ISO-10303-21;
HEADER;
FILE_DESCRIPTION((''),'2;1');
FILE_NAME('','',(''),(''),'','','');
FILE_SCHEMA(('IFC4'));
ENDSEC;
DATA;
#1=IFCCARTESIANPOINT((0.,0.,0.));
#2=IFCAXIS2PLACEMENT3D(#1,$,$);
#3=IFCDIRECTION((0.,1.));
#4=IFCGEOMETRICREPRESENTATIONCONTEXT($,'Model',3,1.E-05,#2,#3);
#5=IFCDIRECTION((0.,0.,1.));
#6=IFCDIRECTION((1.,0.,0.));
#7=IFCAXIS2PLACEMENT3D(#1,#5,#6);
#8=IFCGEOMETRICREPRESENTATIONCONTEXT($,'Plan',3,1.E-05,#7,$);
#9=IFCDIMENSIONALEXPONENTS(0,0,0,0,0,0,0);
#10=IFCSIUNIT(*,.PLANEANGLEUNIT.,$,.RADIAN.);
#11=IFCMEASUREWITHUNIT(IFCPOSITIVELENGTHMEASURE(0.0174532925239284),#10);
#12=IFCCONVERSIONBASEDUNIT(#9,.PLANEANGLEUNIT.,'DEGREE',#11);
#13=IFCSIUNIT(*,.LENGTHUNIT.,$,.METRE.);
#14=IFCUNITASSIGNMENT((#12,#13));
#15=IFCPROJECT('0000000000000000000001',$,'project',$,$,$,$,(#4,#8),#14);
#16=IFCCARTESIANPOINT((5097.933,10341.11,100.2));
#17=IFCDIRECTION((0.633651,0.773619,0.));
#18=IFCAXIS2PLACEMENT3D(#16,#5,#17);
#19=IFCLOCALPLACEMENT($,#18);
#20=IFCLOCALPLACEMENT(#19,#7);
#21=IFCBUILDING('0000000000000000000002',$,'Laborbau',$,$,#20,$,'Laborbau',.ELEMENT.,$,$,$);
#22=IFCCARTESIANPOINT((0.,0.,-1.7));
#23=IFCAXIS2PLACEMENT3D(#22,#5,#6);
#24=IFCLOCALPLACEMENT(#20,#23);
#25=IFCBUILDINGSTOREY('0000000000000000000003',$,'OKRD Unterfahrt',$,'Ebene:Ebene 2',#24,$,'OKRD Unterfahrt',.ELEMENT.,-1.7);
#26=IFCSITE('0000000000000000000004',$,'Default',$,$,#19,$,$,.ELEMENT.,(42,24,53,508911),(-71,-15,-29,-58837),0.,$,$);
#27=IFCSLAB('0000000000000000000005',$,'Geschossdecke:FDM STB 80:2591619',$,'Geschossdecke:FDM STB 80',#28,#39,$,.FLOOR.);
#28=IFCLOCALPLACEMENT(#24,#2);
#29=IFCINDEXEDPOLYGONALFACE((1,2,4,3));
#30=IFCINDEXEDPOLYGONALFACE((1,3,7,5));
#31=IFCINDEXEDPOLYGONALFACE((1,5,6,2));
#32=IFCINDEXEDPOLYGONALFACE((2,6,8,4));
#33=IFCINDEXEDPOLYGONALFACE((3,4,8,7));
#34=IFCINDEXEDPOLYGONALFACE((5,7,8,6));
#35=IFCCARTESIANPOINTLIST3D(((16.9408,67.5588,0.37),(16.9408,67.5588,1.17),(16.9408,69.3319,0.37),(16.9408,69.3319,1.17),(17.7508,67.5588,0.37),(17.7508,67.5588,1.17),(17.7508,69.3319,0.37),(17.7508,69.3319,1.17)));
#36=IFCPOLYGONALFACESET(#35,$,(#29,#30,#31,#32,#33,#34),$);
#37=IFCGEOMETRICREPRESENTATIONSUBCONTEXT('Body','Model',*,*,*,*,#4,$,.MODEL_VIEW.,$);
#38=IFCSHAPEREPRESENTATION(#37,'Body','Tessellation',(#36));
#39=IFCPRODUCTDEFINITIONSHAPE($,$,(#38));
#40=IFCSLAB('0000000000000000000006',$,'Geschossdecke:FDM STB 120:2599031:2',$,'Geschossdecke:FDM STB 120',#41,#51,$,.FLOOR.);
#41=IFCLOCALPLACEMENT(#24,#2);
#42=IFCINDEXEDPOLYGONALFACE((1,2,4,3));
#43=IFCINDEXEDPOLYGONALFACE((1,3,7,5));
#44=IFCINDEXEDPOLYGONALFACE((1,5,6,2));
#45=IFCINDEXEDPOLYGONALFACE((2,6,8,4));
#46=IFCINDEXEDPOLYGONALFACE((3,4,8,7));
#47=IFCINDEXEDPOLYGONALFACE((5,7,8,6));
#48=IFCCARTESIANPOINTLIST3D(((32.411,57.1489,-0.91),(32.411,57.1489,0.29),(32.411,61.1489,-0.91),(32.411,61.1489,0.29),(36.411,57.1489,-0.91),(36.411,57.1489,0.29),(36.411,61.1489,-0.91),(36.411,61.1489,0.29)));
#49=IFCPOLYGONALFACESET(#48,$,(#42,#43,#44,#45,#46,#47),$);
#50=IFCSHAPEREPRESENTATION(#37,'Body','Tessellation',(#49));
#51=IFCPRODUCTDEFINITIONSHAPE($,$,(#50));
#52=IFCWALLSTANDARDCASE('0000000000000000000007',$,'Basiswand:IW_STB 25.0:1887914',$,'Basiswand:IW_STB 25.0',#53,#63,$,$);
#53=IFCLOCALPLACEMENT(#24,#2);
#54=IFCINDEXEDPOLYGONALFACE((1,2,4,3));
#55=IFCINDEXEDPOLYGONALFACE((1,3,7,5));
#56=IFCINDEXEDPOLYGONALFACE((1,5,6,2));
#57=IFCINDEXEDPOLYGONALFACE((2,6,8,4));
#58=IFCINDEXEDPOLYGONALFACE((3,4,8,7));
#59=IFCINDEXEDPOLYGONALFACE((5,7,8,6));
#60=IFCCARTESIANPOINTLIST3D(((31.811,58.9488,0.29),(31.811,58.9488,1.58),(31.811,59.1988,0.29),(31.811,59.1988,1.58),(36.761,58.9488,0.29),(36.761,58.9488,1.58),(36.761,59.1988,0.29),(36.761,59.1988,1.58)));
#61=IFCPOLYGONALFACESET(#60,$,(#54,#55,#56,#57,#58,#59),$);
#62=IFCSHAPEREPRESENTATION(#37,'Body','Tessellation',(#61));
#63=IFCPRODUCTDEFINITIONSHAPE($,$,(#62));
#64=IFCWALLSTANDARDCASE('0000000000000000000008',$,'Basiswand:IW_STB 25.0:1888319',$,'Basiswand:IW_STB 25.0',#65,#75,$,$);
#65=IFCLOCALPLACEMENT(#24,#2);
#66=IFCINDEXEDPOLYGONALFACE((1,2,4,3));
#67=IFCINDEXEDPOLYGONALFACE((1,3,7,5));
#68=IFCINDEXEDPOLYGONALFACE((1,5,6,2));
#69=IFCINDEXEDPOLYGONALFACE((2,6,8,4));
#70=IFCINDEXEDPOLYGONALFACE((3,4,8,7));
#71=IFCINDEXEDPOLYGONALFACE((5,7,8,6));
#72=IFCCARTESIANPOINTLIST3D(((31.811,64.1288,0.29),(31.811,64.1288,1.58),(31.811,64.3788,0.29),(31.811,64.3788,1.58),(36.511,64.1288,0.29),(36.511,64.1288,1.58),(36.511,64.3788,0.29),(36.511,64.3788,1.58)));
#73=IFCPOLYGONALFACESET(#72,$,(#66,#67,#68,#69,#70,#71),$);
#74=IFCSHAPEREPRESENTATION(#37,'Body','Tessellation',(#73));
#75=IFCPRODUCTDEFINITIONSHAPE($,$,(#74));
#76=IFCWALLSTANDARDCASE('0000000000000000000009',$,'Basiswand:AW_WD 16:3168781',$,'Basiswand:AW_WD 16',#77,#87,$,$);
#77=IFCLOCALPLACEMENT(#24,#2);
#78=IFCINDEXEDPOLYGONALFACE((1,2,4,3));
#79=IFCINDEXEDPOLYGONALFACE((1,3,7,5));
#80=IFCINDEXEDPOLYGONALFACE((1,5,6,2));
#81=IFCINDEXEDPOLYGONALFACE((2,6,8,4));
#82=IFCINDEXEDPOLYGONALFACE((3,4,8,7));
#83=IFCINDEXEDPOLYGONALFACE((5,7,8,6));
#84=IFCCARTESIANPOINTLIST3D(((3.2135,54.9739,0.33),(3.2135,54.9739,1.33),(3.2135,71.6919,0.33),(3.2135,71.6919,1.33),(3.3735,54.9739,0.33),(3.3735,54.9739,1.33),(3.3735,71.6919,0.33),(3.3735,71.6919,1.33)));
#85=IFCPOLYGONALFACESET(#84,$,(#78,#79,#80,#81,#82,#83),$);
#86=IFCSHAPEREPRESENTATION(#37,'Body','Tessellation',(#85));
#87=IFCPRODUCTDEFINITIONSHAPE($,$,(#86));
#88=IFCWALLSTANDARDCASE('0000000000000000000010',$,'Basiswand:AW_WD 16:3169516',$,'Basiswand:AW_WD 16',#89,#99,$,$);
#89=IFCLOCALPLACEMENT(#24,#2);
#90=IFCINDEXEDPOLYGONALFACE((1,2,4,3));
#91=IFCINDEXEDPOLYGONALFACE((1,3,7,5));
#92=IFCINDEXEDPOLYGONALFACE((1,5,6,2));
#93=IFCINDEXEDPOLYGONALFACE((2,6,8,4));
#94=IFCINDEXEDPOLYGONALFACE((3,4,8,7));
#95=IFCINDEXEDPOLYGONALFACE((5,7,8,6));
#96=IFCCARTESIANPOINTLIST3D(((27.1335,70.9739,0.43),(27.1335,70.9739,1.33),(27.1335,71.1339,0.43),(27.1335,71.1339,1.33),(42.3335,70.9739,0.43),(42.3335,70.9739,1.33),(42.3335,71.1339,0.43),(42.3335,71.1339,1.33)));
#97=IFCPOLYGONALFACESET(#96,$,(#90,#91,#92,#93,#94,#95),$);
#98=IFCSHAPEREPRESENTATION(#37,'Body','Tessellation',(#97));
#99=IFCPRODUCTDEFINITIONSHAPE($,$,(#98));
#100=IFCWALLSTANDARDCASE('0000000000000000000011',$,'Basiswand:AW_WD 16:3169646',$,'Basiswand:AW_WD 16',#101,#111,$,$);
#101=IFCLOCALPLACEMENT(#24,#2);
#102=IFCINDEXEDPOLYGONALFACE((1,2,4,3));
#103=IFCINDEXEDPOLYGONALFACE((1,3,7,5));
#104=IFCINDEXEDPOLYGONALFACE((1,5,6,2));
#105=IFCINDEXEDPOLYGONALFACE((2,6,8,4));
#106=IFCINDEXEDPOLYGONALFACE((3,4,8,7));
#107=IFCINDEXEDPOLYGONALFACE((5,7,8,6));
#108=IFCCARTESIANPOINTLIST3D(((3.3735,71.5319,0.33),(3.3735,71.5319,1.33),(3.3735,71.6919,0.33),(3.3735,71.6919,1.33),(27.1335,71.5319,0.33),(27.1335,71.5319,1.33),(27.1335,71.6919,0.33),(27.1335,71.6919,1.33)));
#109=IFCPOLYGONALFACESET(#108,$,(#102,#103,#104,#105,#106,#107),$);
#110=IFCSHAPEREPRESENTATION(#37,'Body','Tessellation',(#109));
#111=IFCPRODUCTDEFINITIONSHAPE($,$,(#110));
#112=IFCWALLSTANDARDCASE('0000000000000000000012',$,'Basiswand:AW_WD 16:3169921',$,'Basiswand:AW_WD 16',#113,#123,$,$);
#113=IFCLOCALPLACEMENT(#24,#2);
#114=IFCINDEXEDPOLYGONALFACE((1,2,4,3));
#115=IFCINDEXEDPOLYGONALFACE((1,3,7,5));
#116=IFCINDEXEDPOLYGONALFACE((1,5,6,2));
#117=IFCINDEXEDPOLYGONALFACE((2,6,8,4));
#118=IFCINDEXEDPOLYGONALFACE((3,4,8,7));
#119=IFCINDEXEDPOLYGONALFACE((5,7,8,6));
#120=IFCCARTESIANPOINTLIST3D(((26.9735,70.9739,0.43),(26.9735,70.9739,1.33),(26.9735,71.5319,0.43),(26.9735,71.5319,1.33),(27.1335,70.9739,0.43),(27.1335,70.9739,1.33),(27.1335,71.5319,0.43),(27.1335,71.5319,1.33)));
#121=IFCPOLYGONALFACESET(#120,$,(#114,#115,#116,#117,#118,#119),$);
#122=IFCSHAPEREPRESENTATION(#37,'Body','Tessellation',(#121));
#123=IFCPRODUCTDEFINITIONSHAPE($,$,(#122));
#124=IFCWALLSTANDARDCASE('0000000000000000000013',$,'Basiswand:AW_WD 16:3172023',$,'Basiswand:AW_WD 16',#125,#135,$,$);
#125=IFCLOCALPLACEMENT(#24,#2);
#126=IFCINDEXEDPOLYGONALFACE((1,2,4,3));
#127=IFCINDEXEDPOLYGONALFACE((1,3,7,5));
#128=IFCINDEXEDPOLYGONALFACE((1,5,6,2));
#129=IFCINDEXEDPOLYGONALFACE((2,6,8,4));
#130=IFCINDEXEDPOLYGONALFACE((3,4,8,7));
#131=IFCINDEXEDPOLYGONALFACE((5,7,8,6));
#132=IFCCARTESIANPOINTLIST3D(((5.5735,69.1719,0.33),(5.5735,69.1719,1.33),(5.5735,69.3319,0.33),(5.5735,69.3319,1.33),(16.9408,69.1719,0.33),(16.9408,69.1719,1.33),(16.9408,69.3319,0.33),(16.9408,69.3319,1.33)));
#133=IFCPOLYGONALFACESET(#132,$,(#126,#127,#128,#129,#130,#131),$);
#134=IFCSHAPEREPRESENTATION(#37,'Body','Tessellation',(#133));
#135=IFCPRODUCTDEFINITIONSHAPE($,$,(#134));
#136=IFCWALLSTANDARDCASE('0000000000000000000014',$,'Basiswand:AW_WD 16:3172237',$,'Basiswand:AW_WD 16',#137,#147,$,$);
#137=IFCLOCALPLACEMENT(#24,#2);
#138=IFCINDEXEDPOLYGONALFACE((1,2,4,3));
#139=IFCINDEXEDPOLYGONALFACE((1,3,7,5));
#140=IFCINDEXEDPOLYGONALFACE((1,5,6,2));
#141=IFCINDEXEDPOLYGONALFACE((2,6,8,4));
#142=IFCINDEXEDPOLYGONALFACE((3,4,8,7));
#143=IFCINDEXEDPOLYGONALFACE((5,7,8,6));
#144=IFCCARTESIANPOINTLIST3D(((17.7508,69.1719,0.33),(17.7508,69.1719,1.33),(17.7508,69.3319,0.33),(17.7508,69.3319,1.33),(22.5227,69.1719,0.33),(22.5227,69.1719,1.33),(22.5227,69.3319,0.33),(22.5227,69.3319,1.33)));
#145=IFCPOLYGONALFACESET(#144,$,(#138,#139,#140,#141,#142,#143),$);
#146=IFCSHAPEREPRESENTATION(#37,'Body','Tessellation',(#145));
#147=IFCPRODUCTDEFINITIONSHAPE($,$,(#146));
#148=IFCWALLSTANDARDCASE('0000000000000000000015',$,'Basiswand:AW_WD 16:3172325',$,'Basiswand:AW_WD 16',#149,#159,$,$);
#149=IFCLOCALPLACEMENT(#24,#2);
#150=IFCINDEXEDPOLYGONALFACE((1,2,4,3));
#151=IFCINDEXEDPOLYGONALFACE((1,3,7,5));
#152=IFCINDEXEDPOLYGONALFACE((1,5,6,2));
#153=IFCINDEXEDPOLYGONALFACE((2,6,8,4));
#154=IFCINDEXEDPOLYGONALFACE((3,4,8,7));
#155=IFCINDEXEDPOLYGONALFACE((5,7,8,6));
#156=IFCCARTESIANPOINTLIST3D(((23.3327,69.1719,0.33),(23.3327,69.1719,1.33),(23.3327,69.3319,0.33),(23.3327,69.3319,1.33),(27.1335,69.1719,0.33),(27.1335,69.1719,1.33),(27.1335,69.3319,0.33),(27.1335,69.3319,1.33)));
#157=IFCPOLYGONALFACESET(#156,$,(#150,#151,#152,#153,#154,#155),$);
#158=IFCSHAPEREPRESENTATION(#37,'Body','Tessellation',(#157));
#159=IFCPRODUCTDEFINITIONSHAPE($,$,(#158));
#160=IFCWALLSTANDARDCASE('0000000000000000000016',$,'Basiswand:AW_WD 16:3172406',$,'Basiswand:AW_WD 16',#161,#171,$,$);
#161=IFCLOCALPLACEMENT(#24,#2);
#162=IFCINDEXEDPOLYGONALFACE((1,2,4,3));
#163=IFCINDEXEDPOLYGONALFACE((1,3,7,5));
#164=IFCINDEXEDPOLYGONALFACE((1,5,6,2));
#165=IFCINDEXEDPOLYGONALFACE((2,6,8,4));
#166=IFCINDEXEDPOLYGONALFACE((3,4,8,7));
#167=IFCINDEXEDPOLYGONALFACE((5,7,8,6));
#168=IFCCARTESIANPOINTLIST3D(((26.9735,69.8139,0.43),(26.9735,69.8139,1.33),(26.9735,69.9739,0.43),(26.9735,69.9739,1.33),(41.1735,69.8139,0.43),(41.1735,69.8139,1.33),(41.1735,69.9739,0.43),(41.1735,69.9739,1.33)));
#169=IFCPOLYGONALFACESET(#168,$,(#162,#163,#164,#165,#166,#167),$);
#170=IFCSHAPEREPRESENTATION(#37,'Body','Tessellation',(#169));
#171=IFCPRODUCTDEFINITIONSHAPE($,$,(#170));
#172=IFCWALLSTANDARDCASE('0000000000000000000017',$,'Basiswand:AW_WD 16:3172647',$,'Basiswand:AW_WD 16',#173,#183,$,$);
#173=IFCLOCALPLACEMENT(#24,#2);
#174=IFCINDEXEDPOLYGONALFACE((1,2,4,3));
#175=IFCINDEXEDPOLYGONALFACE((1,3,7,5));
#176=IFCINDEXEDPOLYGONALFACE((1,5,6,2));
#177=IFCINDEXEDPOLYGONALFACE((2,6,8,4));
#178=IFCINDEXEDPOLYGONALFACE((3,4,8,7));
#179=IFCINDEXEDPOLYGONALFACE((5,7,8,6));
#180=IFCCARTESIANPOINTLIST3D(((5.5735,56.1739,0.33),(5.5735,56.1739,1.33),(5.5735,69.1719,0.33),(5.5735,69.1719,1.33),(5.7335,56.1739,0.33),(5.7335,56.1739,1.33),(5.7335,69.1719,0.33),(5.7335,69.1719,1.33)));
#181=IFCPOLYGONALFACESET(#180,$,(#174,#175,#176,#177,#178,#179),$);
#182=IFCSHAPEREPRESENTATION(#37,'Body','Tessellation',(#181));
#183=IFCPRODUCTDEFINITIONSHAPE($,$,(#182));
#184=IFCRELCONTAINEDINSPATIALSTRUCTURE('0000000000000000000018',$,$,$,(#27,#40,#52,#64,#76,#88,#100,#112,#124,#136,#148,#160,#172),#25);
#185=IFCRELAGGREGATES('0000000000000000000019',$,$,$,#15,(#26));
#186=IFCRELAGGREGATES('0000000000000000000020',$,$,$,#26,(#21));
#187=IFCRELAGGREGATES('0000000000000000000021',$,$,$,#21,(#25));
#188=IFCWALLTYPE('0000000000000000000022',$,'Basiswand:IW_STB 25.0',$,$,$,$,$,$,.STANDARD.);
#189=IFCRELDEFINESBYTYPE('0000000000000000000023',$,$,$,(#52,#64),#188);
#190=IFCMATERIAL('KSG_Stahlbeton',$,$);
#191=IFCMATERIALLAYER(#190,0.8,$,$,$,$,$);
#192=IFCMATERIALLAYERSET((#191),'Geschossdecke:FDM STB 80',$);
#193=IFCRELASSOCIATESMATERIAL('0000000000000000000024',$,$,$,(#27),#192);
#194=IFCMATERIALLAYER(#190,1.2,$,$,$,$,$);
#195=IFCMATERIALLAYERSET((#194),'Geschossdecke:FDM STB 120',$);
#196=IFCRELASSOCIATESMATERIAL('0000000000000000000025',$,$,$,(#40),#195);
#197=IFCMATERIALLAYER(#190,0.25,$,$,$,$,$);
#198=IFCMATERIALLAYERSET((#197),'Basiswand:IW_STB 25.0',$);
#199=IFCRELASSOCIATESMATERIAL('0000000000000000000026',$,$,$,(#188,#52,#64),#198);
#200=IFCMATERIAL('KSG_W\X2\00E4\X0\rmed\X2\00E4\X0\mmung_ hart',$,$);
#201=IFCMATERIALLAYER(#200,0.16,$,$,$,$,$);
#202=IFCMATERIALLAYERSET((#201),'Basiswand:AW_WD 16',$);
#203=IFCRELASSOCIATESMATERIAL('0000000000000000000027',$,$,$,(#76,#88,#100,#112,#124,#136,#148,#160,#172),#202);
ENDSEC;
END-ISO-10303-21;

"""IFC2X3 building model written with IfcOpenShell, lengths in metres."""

from ifc_helpers import new_model, entity, si_unit, converted_unit, direction, frame, frame_2d, origin, origin_with_axes, place, context, subcontext, project, spatial, rectangle, extrude, material, layer, layer_set, layer_usage, type_object, element, save


model = new_model("IFC2X3")

# Units and contexts
model_context = context("Model", 3, precision=1e-05, world=origin(), true_north=direction((0.0, 1.0)))
plan_context = context("Plan", 3, precision=1e-05, world=origin_with_axes())
body_context = subcontext(model_context, "Body", "Model", "MODEL_VIEW")
ifc_project = project(units=[converted_unit("PLANEANGLEUNIT", "DEGREE", entity("IfcPositiveLengthMeasure", 0.0174532925239284), si_unit("PLANEANGLEUNIT", "RADIAN"), dimensions=[0, 0, 0, 0, 0, 0, 0]), si_unit("LENGTHUNIT", "METRE")], contexts=[model_context, plan_context])

# Site, building, storey
site_placement = place(None, frame((5097.933, 10341.11, 100.2), z_axis=(0.0, 0.0, 1.0), x_axis=(0.633651, 0.773619, 0.0)))
site = spatial("IfcSite", under=ifc_project, at=site_placement, Name="Default", CompositionType="ELEMENT", RefLatitude=(42, 24, 53, 508911), RefLongitude=(-71, -15, -29, -58837), RefElevation=0.0)
building_placement = place(site_placement, origin_with_axes())
building = spatial("IfcBuilding", under=site, at=building_placement, Name="Laborbau", LongName="Laborbau", CompositionType="ELEMENT")
storey_placement = place(building_placement, frame((0.0, 0.0, -1.7), z_axis=(0.0, 0.0, 1.0), x_axis=(1.0, 0.0, 0.0)))
storey = spatial("IfcBuildingStorey", under=building, at=storey_placement, Name="OKRD Unterfahrt", ObjectType="Ebene:Ebene 2", LongName="OKRD Unterfahrt", CompositionType="ELEMENT", Elevation=-1.7)

# Shared definitions
ifc_material_1 = material(Name="KSG_Wärmedämmung_ hart")

# Slabs
ifc_material_2 = material(Name="KSG_Stahlbeton")
ifc_layer_1 = layer(ifc_material_2, 0.8)
ifc_layer_set_1 = layer_set([ifc_layer_1], Name="Geschossdecke:FDM STB 80")
ifc_layer_usage_1 = layer_usage(ifc_layer_set_1, "AXIS3", "POSITIVE", 0.0)
slab_1_placement = place(storey_placement, frame((16.9408, 67.5588, 0.37), z_axis=(0.0, 0.0, 1.0), x_axis=(1.0, 0.0, 0.0)))
element("IfcSlab", 1, at=slab_1_placement, inside=storey, material=ifc_layer_usage_1, Name="Geschossdecke:FDM STB 80:2591619", ObjectType="Geschossdecke:FDM STB 80", PredefinedType="FLOOR", context=body_context, shape_type="SweptSolid", body=[
    extrude(rectangle(XDim=1.7731, YDim=0.81, at=frame_2d((2.7909, 0.0), x_axis=(0.0, 1.0))), frame((3.1959, 0.8866, 0.8), z_axis=(0.0, 0.0, -1.0), x_axis=(-1.0, 0.0, 0.0)), (0.0, 0.0, 1.0), 0.8),
])
ifc_layer_2 = layer(ifc_material_2, 1.2)
ifc_layer_set_2 = layer_set([ifc_layer_2], Name="Geschossdecke:FDM STB 120")
ifc_layer_usage_2 = layer_usage(ifc_layer_set_2, "AXIS3", "POSITIVE", 0.0)
slab_2_placement = place(storey_placement, frame((32.411, 57.1489, -0.91), z_axis=(0.0, 0.0, 1.0), x_axis=(1.0, 0.0, 0.0)))
element("IfcSlab", 2, at=slab_2_placement, inside=storey, material=ifc_layer_usage_2, Name="Geschossdecke:FDM STB 120:2599031:2", ObjectType="Geschossdecke:FDM STB 120", PredefinedType="FLOOR", context=body_context, shape_type="SweptSolid", body=[
    extrude(rectangle(XDim=4.0, YDim=4.0, at=frame_2d((0.0, -2.515), x_axis=(0.0, -1.0))), frame((2.0, 4.515, 1.2), z_axis=(0.0, 0.0, -1.0), x_axis=(-1.0, 0.0, 0.0)), (0.0, 0.0, 1.0), 1.2),
])

# Walls
ifc_layer_3 = layer(ifc_material_2, 0.25)
ifc_layer_set_3 = layer_set([ifc_layer_3], Name="Basiswand:IW_STB 25.0")
ifc_layer_usage_3 = layer_usage(ifc_layer_set_3, "AXIS2", "NEGATIVE", 0.125)
wall_type = type_object("IfcWallType", Name="Basiswand:IW_STB 25.0", PredefinedType="STANDARD", material=ifc_layer_set_3)
wall_1_placement = place(storey_placement, frame((31.811, 59.0738, 0.29), z_axis=(0.0, 0.0, 1.0), x_axis=(1.0, 0.0, 0.0)))
element("IfcWallStandardCase", 3, at=wall_1_placement, inside=storey, type_object=wall_type, material=ifc_layer_usage_3, Name="Basiswand:IW_STB 25.0:1887914", ObjectType="Basiswand:IW_STB 25.0", context=body_context, shape_type="SweptSolid", body=[
    extrude(rectangle(XDim=4.95, YDim=0.25, at=frame_2d((2.475, 0.0), x_axis=(-1.0, 0.0))), origin(), (0.0, 0.0, 1.0), 1.29),
])
ifc_layer_usage_4 = layer_usage(ifc_layer_set_3, "AXIS2", "NEGATIVE", 0.125)
wall_2_placement = place(storey_placement, frame((31.811, 64.2538, 0.29), z_axis=(0.0, 0.0, 1.0), x_axis=(1.0, 0.0, 0.0)))
element("IfcWallStandardCase", 4, at=wall_2_placement, inside=storey, type_object=wall_type, material=ifc_layer_usage_4, Name="Basiswand:IW_STB 25.0:1888319", ObjectType="Basiswand:IW_STB 25.0", context=body_context, shape_type="SweptSolid", body=[
    extrude(rectangle(XDim=4.7, YDim=0.25, at=frame_2d((2.35, 0.0), x_axis=(-1.0, 0.0))), origin(), (0.0, 0.0, 1.0), 1.29),
])
ifc_layer_4 = layer(ifc_material_1, 0.16)
ifc_layer_set_4 = layer_set([ifc_layer_4], Name="Basiswand:AW_WD 16")
ifc_layer_usage_5 = layer_usage(ifc_layer_set_4, "AXIS2", "NEGATIVE", 0.08)
wall_3_placement = place(storey_placement, frame((3.2935, 54.9739, 0.33), z_axis=(0.0, 0.0, 1.0), x_axis=(0.0, 1.0, 0.0)))
element("IfcWallStandardCase", 5, at=wall_3_placement, inside=storey, material=ifc_layer_usage_5, Name="Basiswand:AW_WD 16:3168781", ObjectType="Basiswand:AW_WD 16", context=body_context, shape_type="SweptSolid", body=[
    extrude(rectangle(XDim=16.718, YDim=0.16, at=frame_2d((8.359, 0.0), x_axis=(-1.0, 0.0))), origin(), (0.0, 0.0, 1.0), 1.0),
])
ifc_layer_usage_6 = layer_usage(ifc_layer_set_4, "AXIS2", "NEGATIVE", 0.08)
wall_4_placement = place(storey_placement, frame((42.3335, 71.0539, 0.43), z_axis=(0.0, 0.0, 1.0), x_axis=(-1.0, 0.0, 0.0)))
element("IfcWallStandardCase", 6, at=wall_4_placement, inside=storey, material=ifc_layer_usage_6, Name="Basiswand:AW_WD 16:3169516", ObjectType="Basiswand:AW_WD 16", context=body_context, shape_type="SweptSolid", body=[
    extrude(rectangle(XDim=15.2, YDim=0.16, at=frame_2d((7.6, 0.0), x_axis=(-1.0, 0.0))), origin(), (0.0, 0.0, 1.0), 0.9),
])
ifc_layer_usage_7 = layer_usage(ifc_layer_set_4, "AXIS2", "NEGATIVE", 0.08)
wall_5_placement = place(storey_placement, frame((27.1335, 71.6119, 0.33), z_axis=(0.0, 0.0, 1.0), x_axis=(-1.0, 0.0, 0.0)))
element("IfcWallStandardCase", 7, at=wall_5_placement, inside=storey, material=ifc_layer_usage_7, Name="Basiswand:AW_WD 16:3169646", ObjectType="Basiswand:AW_WD 16", context=body_context, shape_type="SweptSolid", body=[
    extrude(rectangle(XDim=23.76, YDim=0.16, at=frame_2d((11.88, 0.0), x_axis=(-1.0, 0.0))), origin(), (0.0, 0.0, 1.0), 1.0),
])
ifc_layer_usage_8 = layer_usage(ifc_layer_set_4, "AXIS2", "NEGATIVE", 0.08)
wall_6_placement = place(storey_placement, frame((27.0535, 70.9739, 0.43), z_axis=(0.0, 0.0, 1.0), x_axis=(0.0, 1.0, 0.0)))
element("IfcWallStandardCase", 8, at=wall_6_placement, inside=storey, material=ifc_layer_usage_8, Name="Basiswand:AW_WD 16:3169921", ObjectType="Basiswand:AW_WD 16", context=body_context, shape_type="SweptSolid", body=[
    extrude(rectangle(XDim=0.558, YDim=0.16, at=frame_2d((0.279, 0.0), x_axis=(-1.0, 0.0))), origin(), (0.0, 0.0, 1.0), 0.9),
])
ifc_layer_usage_9 = layer_usage(ifc_layer_set_4, "AXIS2", "NEGATIVE", 0.08)
wall_7_placement = place(storey_placement, frame((16.9408, 69.2519, 0.33), z_axis=(0.0, 0.0, 1.0), x_axis=(-1.0, 0.0, 0.0)))
element("IfcWallStandardCase", 9, at=wall_7_placement, inside=storey, material=ifc_layer_usage_9, Name="Basiswand:AW_WD 16:3172023", ObjectType="Basiswand:AW_WD 16", context=body_context, shape_type="SweptSolid", body=[
    extrude(rectangle(XDim=11.3673, YDim=0.16, at=frame_2d((5.6837, 0.0), x_axis=(-1.0, 0.0))), origin(), (0.0, 0.0, 1.0), 1.0),
])
ifc_layer_usage_10 = layer_usage(ifc_layer_set_4, "AXIS2", "NEGATIVE", 0.08)
wall_8_placement = place(storey_placement, frame((22.5227, 69.2519, 0.33), z_axis=(0.0, 0.0, 1.0), x_axis=(-1.0, 0.0, 0.0)))
element("IfcWallStandardCase", 10, at=wall_8_placement, inside=storey, material=ifc_layer_usage_10, Name="Basiswand:AW_WD 16:3172237", ObjectType="Basiswand:AW_WD 16", context=body_context, shape_type="SweptSolid", body=[
    extrude(rectangle(XDim=4.7719, YDim=0.16, at=frame_2d((2.3859, 0.0), x_axis=(-1.0, 0.0))), origin(), (0.0, 0.0, 1.0), 1.0),
])
ifc_layer_usage_11 = layer_usage(ifc_layer_set_4, "AXIS2", "NEGATIVE", 0.08)
wall_9_placement = place(storey_placement, frame((27.1335, 69.2519, 0.33), z_axis=(0.0, 0.0, 1.0), x_axis=(-1.0, 0.0, 0.0)))
element("IfcWallStandardCase", 11, at=wall_9_placement, inside=storey, material=ifc_layer_usage_11, Name="Basiswand:AW_WD 16:3172325", ObjectType="Basiswand:AW_WD 16", context=body_context, shape_type="SweptSolid", body=[
    extrude(rectangle(XDim=3.8008, YDim=0.16, at=frame_2d((1.9004, 0.0), x_axis=(-1.0, 0.0))), origin(), (0.0, 0.0, 1.0), 1.0),
])
ifc_layer_usage_12 = layer_usage(ifc_layer_set_4, "AXIS2", "NEGATIVE", 0.08)
wall_10_placement = place(storey_placement, frame((41.1735, 69.8939, 0.43), z_axis=(0.0, 0.0, 1.0), x_axis=(-1.0, 0.0, 0.0)))
element("IfcWallStandardCase", 12, at=wall_10_placement, inside=storey, material=ifc_layer_usage_12, Name="Basiswand:AW_WD 16:3172406", ObjectType="Basiswand:AW_WD 16", context=body_context, shape_type="SweptSolid", body=[
    extrude(rectangle(XDim=14.2, YDim=0.16, at=frame_2d((7.1, 0.0), x_axis=(-1.0, 0.0))), origin(), (0.0, 0.0, 1.0), 0.9),
])
ifc_layer_usage_13 = layer_usage(ifc_layer_set_4, "AXIS2", "NEGATIVE", 0.08)
wall_11_placement = place(storey_placement, frame((5.6535, 56.1739, 0.33), z_axis=(0.0, 0.0, 1.0), x_axis=(0.0, 1.0, 0.0)))
element("IfcWallStandardCase", 13, at=wall_11_placement, inside=storey, material=ifc_layer_usage_13, Name="Basiswand:AW_WD 16:3172647", ObjectType="Basiswand:AW_WD 16", context=body_context, shape_type="SweptSolid", body=[
    extrude(rectangle(XDim=12.9981, YDim=0.16, at=frame_2d((6.499, 0.0), x_axis=(-1.0, 0.0))), origin(), (0.0, 0.0, 1.0), 1.0),
])

save(model, "model.ifc")
